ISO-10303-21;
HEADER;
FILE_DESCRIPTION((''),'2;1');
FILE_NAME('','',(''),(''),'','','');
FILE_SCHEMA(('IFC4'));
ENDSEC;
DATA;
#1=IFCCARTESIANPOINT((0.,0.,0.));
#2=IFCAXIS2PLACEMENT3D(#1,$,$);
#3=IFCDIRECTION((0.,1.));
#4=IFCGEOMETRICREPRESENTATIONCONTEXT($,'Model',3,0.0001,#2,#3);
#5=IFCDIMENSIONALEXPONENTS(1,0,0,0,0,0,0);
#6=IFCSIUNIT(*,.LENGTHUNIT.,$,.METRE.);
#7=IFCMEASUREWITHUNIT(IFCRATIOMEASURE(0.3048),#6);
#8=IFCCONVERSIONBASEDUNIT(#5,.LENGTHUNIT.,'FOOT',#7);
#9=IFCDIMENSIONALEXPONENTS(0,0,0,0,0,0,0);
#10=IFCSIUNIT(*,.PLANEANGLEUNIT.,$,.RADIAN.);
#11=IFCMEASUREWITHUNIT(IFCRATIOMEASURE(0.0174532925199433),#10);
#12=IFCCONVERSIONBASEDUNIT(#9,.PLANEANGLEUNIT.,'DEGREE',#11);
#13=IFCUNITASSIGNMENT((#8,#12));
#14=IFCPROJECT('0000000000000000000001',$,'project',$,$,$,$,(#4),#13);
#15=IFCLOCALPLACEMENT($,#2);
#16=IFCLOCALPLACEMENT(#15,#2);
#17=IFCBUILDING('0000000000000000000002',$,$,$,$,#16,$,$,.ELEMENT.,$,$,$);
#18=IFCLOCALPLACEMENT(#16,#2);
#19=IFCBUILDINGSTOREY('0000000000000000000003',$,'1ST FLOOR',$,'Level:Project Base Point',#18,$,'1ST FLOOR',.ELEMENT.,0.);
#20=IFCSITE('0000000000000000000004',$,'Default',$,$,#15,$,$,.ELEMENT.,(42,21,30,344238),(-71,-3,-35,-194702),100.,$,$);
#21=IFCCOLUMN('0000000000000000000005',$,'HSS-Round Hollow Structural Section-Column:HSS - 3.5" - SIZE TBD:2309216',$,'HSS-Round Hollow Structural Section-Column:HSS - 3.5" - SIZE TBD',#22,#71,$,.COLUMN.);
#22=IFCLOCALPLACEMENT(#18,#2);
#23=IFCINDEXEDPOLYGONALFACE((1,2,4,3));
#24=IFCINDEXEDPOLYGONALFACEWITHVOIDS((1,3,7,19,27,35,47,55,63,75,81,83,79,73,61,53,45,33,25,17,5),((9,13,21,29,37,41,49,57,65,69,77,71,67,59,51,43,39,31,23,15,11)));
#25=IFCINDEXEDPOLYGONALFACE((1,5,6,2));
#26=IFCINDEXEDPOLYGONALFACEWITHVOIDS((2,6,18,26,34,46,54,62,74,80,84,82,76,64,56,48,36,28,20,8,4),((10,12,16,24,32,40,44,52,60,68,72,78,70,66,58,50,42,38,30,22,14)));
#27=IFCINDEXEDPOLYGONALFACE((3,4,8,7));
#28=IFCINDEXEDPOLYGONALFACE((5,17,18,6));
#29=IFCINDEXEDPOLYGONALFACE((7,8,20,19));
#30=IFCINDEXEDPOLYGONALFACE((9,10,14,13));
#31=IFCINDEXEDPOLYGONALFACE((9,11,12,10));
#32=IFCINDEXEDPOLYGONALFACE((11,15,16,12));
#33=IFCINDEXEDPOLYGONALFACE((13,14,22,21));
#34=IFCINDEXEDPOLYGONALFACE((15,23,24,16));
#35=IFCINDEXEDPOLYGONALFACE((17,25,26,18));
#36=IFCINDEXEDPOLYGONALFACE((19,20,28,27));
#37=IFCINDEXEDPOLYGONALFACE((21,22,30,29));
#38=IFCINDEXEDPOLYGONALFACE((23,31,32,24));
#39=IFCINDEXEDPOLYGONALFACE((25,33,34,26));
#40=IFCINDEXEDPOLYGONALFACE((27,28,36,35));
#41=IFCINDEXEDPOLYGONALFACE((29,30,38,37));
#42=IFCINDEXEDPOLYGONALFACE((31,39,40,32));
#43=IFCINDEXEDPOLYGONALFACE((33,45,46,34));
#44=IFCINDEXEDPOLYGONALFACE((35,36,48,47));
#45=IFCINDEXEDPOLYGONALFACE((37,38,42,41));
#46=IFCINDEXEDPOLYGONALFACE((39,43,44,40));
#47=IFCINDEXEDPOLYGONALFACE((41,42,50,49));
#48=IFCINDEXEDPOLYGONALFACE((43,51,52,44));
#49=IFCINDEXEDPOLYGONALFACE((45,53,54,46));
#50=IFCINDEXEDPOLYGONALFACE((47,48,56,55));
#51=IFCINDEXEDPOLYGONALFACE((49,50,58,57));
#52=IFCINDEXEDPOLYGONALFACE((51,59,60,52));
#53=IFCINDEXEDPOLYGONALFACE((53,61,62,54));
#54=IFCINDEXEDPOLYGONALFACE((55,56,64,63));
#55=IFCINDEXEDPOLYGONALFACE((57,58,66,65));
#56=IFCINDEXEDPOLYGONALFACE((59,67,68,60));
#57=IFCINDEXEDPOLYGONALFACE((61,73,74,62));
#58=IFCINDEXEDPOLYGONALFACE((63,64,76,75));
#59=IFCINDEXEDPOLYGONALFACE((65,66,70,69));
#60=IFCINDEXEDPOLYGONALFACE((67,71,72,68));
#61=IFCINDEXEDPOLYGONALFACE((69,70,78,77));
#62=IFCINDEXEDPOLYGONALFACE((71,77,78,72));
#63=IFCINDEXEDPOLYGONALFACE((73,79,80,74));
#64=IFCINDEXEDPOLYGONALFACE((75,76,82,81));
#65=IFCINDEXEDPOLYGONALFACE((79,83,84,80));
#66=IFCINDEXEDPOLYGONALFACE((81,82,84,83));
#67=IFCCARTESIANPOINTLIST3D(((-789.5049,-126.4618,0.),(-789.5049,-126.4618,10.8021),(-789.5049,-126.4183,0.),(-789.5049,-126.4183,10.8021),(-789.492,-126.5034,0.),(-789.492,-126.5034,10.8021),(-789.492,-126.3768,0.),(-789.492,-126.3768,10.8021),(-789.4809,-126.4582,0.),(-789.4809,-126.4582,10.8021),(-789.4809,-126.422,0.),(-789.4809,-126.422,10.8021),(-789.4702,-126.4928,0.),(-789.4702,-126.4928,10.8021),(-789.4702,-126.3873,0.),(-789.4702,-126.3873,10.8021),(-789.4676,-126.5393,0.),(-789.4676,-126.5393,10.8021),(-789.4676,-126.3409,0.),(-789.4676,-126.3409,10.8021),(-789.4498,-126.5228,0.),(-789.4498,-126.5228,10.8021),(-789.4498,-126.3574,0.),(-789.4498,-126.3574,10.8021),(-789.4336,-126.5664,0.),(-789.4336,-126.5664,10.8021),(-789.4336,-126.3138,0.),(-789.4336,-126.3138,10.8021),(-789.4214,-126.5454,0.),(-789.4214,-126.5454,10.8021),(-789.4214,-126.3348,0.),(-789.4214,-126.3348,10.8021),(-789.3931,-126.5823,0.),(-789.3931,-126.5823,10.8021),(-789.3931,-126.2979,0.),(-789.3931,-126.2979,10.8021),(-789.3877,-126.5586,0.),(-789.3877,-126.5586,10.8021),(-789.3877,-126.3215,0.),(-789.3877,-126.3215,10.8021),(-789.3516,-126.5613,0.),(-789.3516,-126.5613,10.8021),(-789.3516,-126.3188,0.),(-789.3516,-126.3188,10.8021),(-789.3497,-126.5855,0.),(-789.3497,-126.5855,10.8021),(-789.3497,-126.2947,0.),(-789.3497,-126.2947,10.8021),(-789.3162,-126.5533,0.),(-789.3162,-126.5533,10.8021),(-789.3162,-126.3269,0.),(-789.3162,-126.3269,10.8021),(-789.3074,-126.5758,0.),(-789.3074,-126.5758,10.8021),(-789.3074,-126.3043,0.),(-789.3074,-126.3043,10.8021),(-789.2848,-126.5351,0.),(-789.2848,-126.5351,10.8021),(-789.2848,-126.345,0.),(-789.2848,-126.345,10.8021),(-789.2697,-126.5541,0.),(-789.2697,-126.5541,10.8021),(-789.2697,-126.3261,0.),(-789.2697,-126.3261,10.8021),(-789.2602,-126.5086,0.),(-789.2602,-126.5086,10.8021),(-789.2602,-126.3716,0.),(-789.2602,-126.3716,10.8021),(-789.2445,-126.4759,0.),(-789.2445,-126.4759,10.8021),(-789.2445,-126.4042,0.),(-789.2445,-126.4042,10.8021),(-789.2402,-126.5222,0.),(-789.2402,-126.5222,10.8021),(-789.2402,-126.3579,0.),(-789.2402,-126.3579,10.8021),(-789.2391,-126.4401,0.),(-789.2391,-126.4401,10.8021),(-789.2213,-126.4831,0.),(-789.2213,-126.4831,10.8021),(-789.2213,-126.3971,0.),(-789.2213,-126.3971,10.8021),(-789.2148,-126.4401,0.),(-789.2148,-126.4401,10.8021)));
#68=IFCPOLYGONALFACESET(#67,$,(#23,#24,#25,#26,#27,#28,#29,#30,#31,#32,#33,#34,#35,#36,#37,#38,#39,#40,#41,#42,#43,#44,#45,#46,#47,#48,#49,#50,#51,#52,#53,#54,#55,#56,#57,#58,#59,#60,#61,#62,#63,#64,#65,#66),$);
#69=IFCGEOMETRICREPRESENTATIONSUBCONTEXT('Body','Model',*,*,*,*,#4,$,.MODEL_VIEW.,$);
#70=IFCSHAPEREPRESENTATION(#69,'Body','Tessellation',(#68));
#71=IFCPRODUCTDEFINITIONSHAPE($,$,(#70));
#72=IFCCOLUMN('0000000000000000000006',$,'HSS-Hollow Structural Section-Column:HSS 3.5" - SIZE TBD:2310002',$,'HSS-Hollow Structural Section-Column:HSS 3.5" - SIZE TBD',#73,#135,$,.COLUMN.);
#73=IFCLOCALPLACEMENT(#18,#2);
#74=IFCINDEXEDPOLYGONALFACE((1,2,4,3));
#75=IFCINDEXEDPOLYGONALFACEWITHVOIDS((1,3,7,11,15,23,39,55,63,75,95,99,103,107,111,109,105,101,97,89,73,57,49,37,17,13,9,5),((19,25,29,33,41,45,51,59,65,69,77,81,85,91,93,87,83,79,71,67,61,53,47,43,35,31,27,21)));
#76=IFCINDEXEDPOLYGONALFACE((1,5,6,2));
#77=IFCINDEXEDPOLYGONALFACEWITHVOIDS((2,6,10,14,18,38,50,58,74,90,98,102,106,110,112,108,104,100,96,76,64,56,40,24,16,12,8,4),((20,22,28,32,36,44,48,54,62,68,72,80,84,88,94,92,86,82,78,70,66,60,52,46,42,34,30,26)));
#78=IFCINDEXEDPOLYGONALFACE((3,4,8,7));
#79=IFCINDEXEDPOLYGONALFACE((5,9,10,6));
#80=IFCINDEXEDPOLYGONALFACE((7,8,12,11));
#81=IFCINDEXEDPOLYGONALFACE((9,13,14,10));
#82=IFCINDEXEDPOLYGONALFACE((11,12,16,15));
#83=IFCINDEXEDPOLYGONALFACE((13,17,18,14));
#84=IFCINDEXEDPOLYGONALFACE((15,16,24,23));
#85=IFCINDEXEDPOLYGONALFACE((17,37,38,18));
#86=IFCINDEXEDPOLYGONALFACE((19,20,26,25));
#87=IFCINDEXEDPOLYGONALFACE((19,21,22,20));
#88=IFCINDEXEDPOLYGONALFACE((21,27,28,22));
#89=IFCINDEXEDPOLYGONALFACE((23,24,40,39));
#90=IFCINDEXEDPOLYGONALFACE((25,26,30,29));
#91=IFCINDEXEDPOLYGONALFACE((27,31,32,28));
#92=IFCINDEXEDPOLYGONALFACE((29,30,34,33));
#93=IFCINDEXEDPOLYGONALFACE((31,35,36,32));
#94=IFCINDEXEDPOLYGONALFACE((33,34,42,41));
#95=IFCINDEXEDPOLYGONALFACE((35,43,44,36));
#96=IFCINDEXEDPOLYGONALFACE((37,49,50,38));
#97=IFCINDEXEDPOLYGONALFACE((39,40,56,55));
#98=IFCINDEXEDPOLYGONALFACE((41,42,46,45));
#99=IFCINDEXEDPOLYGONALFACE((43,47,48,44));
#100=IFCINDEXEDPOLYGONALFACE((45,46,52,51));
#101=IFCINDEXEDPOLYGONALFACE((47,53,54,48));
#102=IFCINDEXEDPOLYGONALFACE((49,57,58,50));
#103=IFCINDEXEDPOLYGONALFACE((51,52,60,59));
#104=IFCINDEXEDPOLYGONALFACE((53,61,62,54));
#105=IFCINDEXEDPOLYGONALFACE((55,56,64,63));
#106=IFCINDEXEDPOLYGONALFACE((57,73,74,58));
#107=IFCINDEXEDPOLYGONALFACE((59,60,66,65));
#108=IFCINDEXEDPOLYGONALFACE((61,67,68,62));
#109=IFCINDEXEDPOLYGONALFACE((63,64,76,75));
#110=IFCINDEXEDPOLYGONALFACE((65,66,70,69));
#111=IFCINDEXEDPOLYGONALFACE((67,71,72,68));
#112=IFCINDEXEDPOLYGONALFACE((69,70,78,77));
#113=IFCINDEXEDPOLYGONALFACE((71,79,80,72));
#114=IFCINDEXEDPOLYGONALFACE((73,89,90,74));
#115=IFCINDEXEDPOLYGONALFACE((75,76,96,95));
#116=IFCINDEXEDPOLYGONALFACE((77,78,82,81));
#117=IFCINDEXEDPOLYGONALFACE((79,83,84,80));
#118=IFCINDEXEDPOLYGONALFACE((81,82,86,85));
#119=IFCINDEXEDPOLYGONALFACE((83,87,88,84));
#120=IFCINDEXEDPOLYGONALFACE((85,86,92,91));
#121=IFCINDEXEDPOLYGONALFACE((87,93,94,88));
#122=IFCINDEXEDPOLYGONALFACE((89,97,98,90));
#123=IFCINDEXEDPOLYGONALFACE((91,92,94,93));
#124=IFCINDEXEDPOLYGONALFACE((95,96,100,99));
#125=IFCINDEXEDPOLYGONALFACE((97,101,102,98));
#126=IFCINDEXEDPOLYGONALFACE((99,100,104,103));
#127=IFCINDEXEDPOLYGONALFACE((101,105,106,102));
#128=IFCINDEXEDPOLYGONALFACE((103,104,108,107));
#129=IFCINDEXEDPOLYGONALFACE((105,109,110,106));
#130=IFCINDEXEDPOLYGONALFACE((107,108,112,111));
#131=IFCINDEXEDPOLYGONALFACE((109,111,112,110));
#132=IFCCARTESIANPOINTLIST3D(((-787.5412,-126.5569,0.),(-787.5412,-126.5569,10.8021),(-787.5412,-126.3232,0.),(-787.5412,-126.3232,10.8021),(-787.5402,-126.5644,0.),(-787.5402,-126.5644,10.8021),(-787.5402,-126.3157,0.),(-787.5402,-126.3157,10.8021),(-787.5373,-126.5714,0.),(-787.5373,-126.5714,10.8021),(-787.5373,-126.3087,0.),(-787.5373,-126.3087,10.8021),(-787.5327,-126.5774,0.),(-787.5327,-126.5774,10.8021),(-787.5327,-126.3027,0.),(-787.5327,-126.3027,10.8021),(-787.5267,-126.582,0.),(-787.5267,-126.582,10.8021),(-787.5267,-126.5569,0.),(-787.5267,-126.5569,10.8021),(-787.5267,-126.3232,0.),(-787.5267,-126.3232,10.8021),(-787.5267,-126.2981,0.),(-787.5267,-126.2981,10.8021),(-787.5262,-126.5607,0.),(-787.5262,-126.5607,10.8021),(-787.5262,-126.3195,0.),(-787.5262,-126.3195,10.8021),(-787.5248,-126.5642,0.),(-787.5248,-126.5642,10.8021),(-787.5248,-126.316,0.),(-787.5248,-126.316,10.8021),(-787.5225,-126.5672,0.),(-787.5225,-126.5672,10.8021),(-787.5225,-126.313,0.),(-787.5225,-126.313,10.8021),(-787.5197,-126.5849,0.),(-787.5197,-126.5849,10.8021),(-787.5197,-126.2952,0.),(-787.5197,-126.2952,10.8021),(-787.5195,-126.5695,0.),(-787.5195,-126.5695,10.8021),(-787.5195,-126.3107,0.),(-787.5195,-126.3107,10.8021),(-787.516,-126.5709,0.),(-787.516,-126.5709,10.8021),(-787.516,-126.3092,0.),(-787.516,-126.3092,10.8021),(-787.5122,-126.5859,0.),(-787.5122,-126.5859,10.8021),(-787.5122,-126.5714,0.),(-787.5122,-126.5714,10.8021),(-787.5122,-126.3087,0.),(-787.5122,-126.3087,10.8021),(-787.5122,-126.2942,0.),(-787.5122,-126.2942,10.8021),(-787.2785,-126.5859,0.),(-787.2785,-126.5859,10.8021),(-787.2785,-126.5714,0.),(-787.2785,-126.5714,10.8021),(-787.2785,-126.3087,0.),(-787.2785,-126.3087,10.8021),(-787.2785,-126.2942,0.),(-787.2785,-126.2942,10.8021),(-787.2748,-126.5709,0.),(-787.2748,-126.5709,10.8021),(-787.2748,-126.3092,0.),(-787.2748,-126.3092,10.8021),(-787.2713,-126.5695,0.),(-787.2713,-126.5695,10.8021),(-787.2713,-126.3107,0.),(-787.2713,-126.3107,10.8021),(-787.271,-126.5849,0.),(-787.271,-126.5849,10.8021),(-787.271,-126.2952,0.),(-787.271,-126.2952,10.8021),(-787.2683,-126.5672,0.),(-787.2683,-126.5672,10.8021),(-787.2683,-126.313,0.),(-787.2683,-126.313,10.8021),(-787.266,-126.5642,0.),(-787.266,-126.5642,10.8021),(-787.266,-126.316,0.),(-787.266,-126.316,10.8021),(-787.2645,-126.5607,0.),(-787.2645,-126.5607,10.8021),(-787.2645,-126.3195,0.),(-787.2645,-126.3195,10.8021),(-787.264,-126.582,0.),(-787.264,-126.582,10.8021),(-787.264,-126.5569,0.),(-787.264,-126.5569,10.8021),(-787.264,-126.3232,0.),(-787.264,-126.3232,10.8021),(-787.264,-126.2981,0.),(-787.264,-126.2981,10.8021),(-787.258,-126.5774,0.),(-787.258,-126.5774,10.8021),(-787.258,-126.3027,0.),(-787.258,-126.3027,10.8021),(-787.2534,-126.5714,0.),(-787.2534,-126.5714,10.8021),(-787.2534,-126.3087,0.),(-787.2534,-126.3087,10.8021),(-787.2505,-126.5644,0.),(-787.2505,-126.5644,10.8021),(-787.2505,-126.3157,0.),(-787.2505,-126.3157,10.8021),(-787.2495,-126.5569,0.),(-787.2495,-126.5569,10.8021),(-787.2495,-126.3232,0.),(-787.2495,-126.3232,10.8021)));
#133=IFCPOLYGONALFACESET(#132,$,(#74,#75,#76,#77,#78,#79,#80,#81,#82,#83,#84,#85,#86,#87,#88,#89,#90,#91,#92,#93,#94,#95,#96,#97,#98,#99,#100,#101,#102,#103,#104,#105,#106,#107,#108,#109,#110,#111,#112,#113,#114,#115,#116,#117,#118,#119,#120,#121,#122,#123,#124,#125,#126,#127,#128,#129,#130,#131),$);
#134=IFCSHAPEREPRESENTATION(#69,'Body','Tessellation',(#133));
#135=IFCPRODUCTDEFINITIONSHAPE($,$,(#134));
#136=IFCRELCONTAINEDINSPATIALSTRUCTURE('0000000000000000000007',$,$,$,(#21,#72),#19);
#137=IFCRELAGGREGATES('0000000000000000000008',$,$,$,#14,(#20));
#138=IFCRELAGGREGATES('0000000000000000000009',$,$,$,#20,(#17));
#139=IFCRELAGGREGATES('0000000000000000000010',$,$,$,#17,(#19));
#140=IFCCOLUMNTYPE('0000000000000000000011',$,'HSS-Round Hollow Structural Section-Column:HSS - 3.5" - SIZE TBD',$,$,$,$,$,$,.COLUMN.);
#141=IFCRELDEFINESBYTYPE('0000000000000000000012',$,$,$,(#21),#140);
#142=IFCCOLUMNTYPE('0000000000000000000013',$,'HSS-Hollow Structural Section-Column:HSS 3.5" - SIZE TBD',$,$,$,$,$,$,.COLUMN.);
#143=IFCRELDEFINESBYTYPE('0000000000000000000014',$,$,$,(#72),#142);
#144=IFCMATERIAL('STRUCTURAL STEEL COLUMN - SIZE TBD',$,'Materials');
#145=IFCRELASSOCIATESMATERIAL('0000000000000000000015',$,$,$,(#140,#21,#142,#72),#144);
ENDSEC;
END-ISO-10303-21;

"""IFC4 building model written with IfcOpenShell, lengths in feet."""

from ifc_helpers import new_model, entity, si_unit, converted_unit, direction, frame, frame_2d, origin, place, context, subcontext, project, spatial, polyline, circle_curve, parameter, trimmed, segment, composite_curve, hollow_circle, outline, extrude, source, transform, mapped, material, material_profile, profile_set, profile_usage, type_object, type_shapes, element, save


model = new_model("IFC4")

# Units and contexts
model_context = context("Model", 3, precision=0.0001, world=origin(), true_north=direction((0.0, 1.0)))
body_context = subcontext(model_context, "Body", "Model", "MODEL_VIEW")
ifc_project = project(units=[converted_unit("LENGTHUNIT", "FOOT", entity("IfcRatioMeasure", 0.3048), si_unit("LENGTHUNIT", "METRE"), dimensions=[1, 0, 0, 0, 0, 0, 0]), converted_unit("PLANEANGLEUNIT", "DEGREE", entity("IfcRatioMeasure", 0.0174532925199433), si_unit("PLANEANGLEUNIT", "RADIAN"), dimensions=[0, 0, 0, 0, 0, 0, 0])], contexts=[model_context])

# Site, building, storey
site_placement = place(None, origin())
site = spatial("IfcSite", under=ifc_project, at=site_placement, Name="Default", CompositionType="ELEMENT", RefLatitude=(42, 21, 30, 344238), RefLongitude=(-71, -3, -35, -194702), RefElevation=100.0)
building_placement = place(site_placement, origin())
building = spatial("IfcBuilding", under=site, at=building_placement, CompositionType="ELEMENT")
storey_placement = place(building_placement, origin())
storey = spatial("IfcBuildingStorey", under=building, at=storey_placement, Name="1ST FLOOR", ObjectType="Level:Project Base Point", LongName="1ST FLOOR", CompositionType="ELEMENT", Elevation=0.0)

# Columns
ifc_material_1 = material(Name="STRUCTURAL STEEL COLUMN - SIZE TBD", Category="Materials")
ifc_material_profile_1 = material_profile(ifc_material_1, hollow_circle(Radius=0.1458, WallThickness=0.0242, at=frame_2d((0.0, 0.0), x_axis=(1.0, 0.0))), Name="HSS - 3.5\" - SIZE TBD")
ifc_profile_set_1 = profile_set([ifc_material_profile_1], Name="HSS - 3.5\" - SIZE TBD")
ifc_profile_usage_1 = profile_usage(ifc_profile_set_1)
column_type_1 = type_object("IfcColumnType", Name="HSS-Round Hollow Structural Section-Column:HSS - 3.5\" - SIZE TBD", PredefinedType="COLUMN", material=ifc_profile_set_1)
shared_shape_1 = source(origin(), body_context, "Body", "SweptSolid", [
    extrude(hollow_circle(Radius=0.1458, WallThickness=0.0242, at=frame_2d((0.0, 0.0), x_axis=(1.0, 0.0))), origin(), (0.0, 0.0, 1.0), 10.8021),
])
type_shapes(column_type_1, [shared_shape_1])
column_1_placement = place(storey_placement, frame((-789.3606, -126.4401, 0.0)))
element("IfcColumn", 1, at=column_1_placement, inside=storey, type_object=column_type_1, material=ifc_profile_usage_1, Name="HSS-Round Hollow Structural Section-Column:HSS - 3.5\" - SIZE TBD:2309216", ObjectType="HSS-Round Hollow Structural Section-Column:HSS - 3.5\" - SIZE TBD", PredefinedType="COLUMN", context=body_context, shape_type="MappedRepresentation", body=[
    mapped(shared_shape_1, transform((0.0, 0.0, 0.0), scale=1.0)),
])
ifc_material_profile_2 = material_profile(ifc_material_1, outline(composite_curve([segment(polyline([(-0.1168, -0.1458), (0.1168, -0.1458)]), True, "CONTINUOUS"), segment(trimmed(circle_curve(frame_2d((0.1168, -0.1168), x_axis=(-1.0, 0.0)), 0.029), [parameter(90.0)], [parameter(180.0)], True, "PARAMETER"), True, "CONTINUOUS"), segment(polyline([(0.1458, -0.1168), (0.1458, 0.1168)]), True, "CONTINUOUS"), segment(trimmed(circle_curve(frame_2d((0.1168, 0.1168), x_axis=(-1.0, 0.0)), 0.029), [parameter(180.0)], [parameter(270.0)], True, "PARAMETER"), True, "CONTINUOUS"), segment(polyline([(0.1168, 0.1458), (-0.1168, 0.1458)]), True, "CONTINUOUS"), segment(trimmed(circle_curve(frame_2d((-0.1168, 0.1168), x_axis=(-1.0, 0.0)), 0.029), [parameter(270.0)], [parameter(360.0)], True, "PARAMETER"), True, "CONTINUOUS"), segment(polyline([(-0.1458, 0.1168), (-0.1458, -0.1168)]), True, "CONTINUOUS"), segment(trimmed(circle_curve(frame_2d((-0.1168, -0.1168), x_axis=(-1.0, 0.0)), 0.029), [parameter(360.0)], [parameter(90.0)], True, "PARAMETER"), True, "CONTINUOUS")], self_intersect=False), holes=[composite_curve([segment(trimmed(circle_curve(frame_2d((-0.1168, -0.1168), x_axis=(-1.0, 0.0)), 0.0145), [parameter(0.0)], [parameter(90.0)], True, "PARAMETER"), False, "CONTINUOUS"), segment(polyline([(-0.1313, -0.1168), (-0.1313, 0.1168)]), True, "CONTINUOUS"), segment(trimmed(circle_curve(frame_2d((-0.1168, 0.1168), x_axis=(-1.0, 0.0)), 0.0145), [parameter(270.0)], [parameter(360.0)], True, "PARAMETER"), False, "CONTINUOUS"), segment(polyline([(-0.1168, 0.1313), (0.1168, 0.1313)]), True, "CONTINUOUS"), segment(trimmed(circle_curve(frame_2d((0.1168, 0.1168), x_axis=(-1.0, 0.0)), 0.0145), [parameter(180.0)], [parameter(270.0)], True, "PARAMETER"), False, "CONTINUOUS"), segment(polyline([(0.1313, 0.1168), (0.1313, -0.1168)]), True, "CONTINUOUS"), segment(trimmed(circle_curve(frame_2d((0.1168, -0.1168), x_axis=(-1.0, 0.0)), 0.0145), [parameter(90.0)], [parameter(180.0)], True, "PARAMETER"), False, "CONTINUOUS"), segment(polyline([(0.1168, -0.1313), (-0.1168, -0.1313)]), True, "CONTINUOUS")], self_intersect=False)]), Name="HSS 3.5\" - SIZE TBD")
ifc_profile_set_2 = profile_set([ifc_material_profile_2], Name="HSS 3.5\" - SIZE TBD")
ifc_profile_usage_2 = profile_usage(ifc_profile_set_2)
column_type_2 = type_object("IfcColumnType", Name="HSS-Hollow Structural Section-Column:HSS 3.5\" - SIZE TBD", PredefinedType="COLUMN", material=ifc_profile_set_2)
shared_shape_2 = source(origin(), body_context, "Body", "SweptSolid", [
    extrude(outline(composite_curve([segment(polyline([(-0.1168, -0.1458), (0.1168, -0.1458)]), True, "CONTINUOUS"), segment(trimmed(circle_curve(frame_2d((0.1168, -0.1168), x_axis=(-1.0, 0.0)), 0.029), [parameter(90.0)], [parameter(180.0)], True, "PARAMETER"), True, "CONTINUOUS"), segment(polyline([(0.1458, -0.1168), (0.1458, 0.1168)]), True, "CONTINUOUS"), segment(trimmed(circle_curve(frame_2d((0.1168, 0.1168), x_axis=(-1.0, 0.0)), 0.029), [parameter(180.0)], [parameter(270.0)], True, "PARAMETER"), True, "CONTINUOUS"), segment(polyline([(0.1168, 0.1458), (-0.1168, 0.1458)]), True, "CONTINUOUS"), segment(trimmed(circle_curve(frame_2d((-0.1168, 0.1168), x_axis=(-1.0, 0.0)), 0.029), [parameter(270.0)], [parameter(360.0)], True, "PARAMETER"), True, "CONTINUOUS"), segment(polyline([(-0.1458, 0.1168), (-0.1458, -0.1168)]), True, "CONTINUOUS"), segment(trimmed(circle_curve(frame_2d((-0.1168, -0.1168), x_axis=(-1.0, 0.0)), 0.029), [parameter(360.0)], [parameter(90.0)], True, "PARAMETER"), True, "CONTINUOUS")], self_intersect=False), holes=[composite_curve([segment(trimmed(circle_curve(frame_2d((-0.1168, -0.1168), x_axis=(-1.0, 0.0)), 0.0145), [parameter(0.0)], [parameter(90.0)], True, "PARAMETER"), False, "CONTINUOUS"), segment(polyline([(-0.1313, -0.1168), (-0.1313, 0.1168)]), True, "CONTINUOUS"), segment(trimmed(circle_curve(frame_2d((-0.1168, 0.1168), x_axis=(-1.0, 0.0)), 0.0145), [parameter(270.0)], [parameter(360.0)], True, "PARAMETER"), False, "CONTINUOUS"), segment(polyline([(-0.1168, 0.1313), (0.1168, 0.1313)]), True, "CONTINUOUS"), segment(trimmed(circle_curve(frame_2d((0.1168, 0.1168), x_axis=(-1.0, 0.0)), 0.0145), [parameter(180.0)], [parameter(270.0)], True, "PARAMETER"), False, "CONTINUOUS"), segment(polyline([(0.1313, 0.1168), (0.1313, -0.1168)]), True, "CONTINUOUS"), segment(trimmed(circle_curve(frame_2d((0.1168, -0.1168), x_axis=(-1.0, 0.0)), 0.0145), [parameter(90.0)], [parameter(180.0)], True, "PARAMETER"), False, "CONTINUOUS"), segment(polyline([(0.1168, -0.1313), (-0.1168, -0.1313)]), True, "CONTINUOUS")], self_intersect=False)]), frame((0.0, 0.0, 0.0), z_axis=(0.0, 0.0, 1.0), x_axis=(-1.0, 0.0, 0.0)), (0.0, 0.0, 1.0), 10.8021),
])
type_shapes(column_type_2, [shared_shape_2])
column_2_placement = place(storey_placement, frame((-787.3954, -126.4401, 0.0)))
element("IfcColumn", 2, at=column_2_placement, inside=storey, type_object=column_type_2, material=ifc_profile_usage_2, Name="HSS-Hollow Structural Section-Column:HSS 3.5\" - SIZE TBD:2310002", ObjectType="HSS-Hollow Structural Section-Column:HSS 3.5\" - SIZE TBD", PredefinedType="COLUMN", context=body_context, shape_type="MappedRepresentation", body=[
    mapped(shared_shape_2, transform((0.0, 0.0, 0.0), scale=1.0)),
])

save(model, "model.ifc")
